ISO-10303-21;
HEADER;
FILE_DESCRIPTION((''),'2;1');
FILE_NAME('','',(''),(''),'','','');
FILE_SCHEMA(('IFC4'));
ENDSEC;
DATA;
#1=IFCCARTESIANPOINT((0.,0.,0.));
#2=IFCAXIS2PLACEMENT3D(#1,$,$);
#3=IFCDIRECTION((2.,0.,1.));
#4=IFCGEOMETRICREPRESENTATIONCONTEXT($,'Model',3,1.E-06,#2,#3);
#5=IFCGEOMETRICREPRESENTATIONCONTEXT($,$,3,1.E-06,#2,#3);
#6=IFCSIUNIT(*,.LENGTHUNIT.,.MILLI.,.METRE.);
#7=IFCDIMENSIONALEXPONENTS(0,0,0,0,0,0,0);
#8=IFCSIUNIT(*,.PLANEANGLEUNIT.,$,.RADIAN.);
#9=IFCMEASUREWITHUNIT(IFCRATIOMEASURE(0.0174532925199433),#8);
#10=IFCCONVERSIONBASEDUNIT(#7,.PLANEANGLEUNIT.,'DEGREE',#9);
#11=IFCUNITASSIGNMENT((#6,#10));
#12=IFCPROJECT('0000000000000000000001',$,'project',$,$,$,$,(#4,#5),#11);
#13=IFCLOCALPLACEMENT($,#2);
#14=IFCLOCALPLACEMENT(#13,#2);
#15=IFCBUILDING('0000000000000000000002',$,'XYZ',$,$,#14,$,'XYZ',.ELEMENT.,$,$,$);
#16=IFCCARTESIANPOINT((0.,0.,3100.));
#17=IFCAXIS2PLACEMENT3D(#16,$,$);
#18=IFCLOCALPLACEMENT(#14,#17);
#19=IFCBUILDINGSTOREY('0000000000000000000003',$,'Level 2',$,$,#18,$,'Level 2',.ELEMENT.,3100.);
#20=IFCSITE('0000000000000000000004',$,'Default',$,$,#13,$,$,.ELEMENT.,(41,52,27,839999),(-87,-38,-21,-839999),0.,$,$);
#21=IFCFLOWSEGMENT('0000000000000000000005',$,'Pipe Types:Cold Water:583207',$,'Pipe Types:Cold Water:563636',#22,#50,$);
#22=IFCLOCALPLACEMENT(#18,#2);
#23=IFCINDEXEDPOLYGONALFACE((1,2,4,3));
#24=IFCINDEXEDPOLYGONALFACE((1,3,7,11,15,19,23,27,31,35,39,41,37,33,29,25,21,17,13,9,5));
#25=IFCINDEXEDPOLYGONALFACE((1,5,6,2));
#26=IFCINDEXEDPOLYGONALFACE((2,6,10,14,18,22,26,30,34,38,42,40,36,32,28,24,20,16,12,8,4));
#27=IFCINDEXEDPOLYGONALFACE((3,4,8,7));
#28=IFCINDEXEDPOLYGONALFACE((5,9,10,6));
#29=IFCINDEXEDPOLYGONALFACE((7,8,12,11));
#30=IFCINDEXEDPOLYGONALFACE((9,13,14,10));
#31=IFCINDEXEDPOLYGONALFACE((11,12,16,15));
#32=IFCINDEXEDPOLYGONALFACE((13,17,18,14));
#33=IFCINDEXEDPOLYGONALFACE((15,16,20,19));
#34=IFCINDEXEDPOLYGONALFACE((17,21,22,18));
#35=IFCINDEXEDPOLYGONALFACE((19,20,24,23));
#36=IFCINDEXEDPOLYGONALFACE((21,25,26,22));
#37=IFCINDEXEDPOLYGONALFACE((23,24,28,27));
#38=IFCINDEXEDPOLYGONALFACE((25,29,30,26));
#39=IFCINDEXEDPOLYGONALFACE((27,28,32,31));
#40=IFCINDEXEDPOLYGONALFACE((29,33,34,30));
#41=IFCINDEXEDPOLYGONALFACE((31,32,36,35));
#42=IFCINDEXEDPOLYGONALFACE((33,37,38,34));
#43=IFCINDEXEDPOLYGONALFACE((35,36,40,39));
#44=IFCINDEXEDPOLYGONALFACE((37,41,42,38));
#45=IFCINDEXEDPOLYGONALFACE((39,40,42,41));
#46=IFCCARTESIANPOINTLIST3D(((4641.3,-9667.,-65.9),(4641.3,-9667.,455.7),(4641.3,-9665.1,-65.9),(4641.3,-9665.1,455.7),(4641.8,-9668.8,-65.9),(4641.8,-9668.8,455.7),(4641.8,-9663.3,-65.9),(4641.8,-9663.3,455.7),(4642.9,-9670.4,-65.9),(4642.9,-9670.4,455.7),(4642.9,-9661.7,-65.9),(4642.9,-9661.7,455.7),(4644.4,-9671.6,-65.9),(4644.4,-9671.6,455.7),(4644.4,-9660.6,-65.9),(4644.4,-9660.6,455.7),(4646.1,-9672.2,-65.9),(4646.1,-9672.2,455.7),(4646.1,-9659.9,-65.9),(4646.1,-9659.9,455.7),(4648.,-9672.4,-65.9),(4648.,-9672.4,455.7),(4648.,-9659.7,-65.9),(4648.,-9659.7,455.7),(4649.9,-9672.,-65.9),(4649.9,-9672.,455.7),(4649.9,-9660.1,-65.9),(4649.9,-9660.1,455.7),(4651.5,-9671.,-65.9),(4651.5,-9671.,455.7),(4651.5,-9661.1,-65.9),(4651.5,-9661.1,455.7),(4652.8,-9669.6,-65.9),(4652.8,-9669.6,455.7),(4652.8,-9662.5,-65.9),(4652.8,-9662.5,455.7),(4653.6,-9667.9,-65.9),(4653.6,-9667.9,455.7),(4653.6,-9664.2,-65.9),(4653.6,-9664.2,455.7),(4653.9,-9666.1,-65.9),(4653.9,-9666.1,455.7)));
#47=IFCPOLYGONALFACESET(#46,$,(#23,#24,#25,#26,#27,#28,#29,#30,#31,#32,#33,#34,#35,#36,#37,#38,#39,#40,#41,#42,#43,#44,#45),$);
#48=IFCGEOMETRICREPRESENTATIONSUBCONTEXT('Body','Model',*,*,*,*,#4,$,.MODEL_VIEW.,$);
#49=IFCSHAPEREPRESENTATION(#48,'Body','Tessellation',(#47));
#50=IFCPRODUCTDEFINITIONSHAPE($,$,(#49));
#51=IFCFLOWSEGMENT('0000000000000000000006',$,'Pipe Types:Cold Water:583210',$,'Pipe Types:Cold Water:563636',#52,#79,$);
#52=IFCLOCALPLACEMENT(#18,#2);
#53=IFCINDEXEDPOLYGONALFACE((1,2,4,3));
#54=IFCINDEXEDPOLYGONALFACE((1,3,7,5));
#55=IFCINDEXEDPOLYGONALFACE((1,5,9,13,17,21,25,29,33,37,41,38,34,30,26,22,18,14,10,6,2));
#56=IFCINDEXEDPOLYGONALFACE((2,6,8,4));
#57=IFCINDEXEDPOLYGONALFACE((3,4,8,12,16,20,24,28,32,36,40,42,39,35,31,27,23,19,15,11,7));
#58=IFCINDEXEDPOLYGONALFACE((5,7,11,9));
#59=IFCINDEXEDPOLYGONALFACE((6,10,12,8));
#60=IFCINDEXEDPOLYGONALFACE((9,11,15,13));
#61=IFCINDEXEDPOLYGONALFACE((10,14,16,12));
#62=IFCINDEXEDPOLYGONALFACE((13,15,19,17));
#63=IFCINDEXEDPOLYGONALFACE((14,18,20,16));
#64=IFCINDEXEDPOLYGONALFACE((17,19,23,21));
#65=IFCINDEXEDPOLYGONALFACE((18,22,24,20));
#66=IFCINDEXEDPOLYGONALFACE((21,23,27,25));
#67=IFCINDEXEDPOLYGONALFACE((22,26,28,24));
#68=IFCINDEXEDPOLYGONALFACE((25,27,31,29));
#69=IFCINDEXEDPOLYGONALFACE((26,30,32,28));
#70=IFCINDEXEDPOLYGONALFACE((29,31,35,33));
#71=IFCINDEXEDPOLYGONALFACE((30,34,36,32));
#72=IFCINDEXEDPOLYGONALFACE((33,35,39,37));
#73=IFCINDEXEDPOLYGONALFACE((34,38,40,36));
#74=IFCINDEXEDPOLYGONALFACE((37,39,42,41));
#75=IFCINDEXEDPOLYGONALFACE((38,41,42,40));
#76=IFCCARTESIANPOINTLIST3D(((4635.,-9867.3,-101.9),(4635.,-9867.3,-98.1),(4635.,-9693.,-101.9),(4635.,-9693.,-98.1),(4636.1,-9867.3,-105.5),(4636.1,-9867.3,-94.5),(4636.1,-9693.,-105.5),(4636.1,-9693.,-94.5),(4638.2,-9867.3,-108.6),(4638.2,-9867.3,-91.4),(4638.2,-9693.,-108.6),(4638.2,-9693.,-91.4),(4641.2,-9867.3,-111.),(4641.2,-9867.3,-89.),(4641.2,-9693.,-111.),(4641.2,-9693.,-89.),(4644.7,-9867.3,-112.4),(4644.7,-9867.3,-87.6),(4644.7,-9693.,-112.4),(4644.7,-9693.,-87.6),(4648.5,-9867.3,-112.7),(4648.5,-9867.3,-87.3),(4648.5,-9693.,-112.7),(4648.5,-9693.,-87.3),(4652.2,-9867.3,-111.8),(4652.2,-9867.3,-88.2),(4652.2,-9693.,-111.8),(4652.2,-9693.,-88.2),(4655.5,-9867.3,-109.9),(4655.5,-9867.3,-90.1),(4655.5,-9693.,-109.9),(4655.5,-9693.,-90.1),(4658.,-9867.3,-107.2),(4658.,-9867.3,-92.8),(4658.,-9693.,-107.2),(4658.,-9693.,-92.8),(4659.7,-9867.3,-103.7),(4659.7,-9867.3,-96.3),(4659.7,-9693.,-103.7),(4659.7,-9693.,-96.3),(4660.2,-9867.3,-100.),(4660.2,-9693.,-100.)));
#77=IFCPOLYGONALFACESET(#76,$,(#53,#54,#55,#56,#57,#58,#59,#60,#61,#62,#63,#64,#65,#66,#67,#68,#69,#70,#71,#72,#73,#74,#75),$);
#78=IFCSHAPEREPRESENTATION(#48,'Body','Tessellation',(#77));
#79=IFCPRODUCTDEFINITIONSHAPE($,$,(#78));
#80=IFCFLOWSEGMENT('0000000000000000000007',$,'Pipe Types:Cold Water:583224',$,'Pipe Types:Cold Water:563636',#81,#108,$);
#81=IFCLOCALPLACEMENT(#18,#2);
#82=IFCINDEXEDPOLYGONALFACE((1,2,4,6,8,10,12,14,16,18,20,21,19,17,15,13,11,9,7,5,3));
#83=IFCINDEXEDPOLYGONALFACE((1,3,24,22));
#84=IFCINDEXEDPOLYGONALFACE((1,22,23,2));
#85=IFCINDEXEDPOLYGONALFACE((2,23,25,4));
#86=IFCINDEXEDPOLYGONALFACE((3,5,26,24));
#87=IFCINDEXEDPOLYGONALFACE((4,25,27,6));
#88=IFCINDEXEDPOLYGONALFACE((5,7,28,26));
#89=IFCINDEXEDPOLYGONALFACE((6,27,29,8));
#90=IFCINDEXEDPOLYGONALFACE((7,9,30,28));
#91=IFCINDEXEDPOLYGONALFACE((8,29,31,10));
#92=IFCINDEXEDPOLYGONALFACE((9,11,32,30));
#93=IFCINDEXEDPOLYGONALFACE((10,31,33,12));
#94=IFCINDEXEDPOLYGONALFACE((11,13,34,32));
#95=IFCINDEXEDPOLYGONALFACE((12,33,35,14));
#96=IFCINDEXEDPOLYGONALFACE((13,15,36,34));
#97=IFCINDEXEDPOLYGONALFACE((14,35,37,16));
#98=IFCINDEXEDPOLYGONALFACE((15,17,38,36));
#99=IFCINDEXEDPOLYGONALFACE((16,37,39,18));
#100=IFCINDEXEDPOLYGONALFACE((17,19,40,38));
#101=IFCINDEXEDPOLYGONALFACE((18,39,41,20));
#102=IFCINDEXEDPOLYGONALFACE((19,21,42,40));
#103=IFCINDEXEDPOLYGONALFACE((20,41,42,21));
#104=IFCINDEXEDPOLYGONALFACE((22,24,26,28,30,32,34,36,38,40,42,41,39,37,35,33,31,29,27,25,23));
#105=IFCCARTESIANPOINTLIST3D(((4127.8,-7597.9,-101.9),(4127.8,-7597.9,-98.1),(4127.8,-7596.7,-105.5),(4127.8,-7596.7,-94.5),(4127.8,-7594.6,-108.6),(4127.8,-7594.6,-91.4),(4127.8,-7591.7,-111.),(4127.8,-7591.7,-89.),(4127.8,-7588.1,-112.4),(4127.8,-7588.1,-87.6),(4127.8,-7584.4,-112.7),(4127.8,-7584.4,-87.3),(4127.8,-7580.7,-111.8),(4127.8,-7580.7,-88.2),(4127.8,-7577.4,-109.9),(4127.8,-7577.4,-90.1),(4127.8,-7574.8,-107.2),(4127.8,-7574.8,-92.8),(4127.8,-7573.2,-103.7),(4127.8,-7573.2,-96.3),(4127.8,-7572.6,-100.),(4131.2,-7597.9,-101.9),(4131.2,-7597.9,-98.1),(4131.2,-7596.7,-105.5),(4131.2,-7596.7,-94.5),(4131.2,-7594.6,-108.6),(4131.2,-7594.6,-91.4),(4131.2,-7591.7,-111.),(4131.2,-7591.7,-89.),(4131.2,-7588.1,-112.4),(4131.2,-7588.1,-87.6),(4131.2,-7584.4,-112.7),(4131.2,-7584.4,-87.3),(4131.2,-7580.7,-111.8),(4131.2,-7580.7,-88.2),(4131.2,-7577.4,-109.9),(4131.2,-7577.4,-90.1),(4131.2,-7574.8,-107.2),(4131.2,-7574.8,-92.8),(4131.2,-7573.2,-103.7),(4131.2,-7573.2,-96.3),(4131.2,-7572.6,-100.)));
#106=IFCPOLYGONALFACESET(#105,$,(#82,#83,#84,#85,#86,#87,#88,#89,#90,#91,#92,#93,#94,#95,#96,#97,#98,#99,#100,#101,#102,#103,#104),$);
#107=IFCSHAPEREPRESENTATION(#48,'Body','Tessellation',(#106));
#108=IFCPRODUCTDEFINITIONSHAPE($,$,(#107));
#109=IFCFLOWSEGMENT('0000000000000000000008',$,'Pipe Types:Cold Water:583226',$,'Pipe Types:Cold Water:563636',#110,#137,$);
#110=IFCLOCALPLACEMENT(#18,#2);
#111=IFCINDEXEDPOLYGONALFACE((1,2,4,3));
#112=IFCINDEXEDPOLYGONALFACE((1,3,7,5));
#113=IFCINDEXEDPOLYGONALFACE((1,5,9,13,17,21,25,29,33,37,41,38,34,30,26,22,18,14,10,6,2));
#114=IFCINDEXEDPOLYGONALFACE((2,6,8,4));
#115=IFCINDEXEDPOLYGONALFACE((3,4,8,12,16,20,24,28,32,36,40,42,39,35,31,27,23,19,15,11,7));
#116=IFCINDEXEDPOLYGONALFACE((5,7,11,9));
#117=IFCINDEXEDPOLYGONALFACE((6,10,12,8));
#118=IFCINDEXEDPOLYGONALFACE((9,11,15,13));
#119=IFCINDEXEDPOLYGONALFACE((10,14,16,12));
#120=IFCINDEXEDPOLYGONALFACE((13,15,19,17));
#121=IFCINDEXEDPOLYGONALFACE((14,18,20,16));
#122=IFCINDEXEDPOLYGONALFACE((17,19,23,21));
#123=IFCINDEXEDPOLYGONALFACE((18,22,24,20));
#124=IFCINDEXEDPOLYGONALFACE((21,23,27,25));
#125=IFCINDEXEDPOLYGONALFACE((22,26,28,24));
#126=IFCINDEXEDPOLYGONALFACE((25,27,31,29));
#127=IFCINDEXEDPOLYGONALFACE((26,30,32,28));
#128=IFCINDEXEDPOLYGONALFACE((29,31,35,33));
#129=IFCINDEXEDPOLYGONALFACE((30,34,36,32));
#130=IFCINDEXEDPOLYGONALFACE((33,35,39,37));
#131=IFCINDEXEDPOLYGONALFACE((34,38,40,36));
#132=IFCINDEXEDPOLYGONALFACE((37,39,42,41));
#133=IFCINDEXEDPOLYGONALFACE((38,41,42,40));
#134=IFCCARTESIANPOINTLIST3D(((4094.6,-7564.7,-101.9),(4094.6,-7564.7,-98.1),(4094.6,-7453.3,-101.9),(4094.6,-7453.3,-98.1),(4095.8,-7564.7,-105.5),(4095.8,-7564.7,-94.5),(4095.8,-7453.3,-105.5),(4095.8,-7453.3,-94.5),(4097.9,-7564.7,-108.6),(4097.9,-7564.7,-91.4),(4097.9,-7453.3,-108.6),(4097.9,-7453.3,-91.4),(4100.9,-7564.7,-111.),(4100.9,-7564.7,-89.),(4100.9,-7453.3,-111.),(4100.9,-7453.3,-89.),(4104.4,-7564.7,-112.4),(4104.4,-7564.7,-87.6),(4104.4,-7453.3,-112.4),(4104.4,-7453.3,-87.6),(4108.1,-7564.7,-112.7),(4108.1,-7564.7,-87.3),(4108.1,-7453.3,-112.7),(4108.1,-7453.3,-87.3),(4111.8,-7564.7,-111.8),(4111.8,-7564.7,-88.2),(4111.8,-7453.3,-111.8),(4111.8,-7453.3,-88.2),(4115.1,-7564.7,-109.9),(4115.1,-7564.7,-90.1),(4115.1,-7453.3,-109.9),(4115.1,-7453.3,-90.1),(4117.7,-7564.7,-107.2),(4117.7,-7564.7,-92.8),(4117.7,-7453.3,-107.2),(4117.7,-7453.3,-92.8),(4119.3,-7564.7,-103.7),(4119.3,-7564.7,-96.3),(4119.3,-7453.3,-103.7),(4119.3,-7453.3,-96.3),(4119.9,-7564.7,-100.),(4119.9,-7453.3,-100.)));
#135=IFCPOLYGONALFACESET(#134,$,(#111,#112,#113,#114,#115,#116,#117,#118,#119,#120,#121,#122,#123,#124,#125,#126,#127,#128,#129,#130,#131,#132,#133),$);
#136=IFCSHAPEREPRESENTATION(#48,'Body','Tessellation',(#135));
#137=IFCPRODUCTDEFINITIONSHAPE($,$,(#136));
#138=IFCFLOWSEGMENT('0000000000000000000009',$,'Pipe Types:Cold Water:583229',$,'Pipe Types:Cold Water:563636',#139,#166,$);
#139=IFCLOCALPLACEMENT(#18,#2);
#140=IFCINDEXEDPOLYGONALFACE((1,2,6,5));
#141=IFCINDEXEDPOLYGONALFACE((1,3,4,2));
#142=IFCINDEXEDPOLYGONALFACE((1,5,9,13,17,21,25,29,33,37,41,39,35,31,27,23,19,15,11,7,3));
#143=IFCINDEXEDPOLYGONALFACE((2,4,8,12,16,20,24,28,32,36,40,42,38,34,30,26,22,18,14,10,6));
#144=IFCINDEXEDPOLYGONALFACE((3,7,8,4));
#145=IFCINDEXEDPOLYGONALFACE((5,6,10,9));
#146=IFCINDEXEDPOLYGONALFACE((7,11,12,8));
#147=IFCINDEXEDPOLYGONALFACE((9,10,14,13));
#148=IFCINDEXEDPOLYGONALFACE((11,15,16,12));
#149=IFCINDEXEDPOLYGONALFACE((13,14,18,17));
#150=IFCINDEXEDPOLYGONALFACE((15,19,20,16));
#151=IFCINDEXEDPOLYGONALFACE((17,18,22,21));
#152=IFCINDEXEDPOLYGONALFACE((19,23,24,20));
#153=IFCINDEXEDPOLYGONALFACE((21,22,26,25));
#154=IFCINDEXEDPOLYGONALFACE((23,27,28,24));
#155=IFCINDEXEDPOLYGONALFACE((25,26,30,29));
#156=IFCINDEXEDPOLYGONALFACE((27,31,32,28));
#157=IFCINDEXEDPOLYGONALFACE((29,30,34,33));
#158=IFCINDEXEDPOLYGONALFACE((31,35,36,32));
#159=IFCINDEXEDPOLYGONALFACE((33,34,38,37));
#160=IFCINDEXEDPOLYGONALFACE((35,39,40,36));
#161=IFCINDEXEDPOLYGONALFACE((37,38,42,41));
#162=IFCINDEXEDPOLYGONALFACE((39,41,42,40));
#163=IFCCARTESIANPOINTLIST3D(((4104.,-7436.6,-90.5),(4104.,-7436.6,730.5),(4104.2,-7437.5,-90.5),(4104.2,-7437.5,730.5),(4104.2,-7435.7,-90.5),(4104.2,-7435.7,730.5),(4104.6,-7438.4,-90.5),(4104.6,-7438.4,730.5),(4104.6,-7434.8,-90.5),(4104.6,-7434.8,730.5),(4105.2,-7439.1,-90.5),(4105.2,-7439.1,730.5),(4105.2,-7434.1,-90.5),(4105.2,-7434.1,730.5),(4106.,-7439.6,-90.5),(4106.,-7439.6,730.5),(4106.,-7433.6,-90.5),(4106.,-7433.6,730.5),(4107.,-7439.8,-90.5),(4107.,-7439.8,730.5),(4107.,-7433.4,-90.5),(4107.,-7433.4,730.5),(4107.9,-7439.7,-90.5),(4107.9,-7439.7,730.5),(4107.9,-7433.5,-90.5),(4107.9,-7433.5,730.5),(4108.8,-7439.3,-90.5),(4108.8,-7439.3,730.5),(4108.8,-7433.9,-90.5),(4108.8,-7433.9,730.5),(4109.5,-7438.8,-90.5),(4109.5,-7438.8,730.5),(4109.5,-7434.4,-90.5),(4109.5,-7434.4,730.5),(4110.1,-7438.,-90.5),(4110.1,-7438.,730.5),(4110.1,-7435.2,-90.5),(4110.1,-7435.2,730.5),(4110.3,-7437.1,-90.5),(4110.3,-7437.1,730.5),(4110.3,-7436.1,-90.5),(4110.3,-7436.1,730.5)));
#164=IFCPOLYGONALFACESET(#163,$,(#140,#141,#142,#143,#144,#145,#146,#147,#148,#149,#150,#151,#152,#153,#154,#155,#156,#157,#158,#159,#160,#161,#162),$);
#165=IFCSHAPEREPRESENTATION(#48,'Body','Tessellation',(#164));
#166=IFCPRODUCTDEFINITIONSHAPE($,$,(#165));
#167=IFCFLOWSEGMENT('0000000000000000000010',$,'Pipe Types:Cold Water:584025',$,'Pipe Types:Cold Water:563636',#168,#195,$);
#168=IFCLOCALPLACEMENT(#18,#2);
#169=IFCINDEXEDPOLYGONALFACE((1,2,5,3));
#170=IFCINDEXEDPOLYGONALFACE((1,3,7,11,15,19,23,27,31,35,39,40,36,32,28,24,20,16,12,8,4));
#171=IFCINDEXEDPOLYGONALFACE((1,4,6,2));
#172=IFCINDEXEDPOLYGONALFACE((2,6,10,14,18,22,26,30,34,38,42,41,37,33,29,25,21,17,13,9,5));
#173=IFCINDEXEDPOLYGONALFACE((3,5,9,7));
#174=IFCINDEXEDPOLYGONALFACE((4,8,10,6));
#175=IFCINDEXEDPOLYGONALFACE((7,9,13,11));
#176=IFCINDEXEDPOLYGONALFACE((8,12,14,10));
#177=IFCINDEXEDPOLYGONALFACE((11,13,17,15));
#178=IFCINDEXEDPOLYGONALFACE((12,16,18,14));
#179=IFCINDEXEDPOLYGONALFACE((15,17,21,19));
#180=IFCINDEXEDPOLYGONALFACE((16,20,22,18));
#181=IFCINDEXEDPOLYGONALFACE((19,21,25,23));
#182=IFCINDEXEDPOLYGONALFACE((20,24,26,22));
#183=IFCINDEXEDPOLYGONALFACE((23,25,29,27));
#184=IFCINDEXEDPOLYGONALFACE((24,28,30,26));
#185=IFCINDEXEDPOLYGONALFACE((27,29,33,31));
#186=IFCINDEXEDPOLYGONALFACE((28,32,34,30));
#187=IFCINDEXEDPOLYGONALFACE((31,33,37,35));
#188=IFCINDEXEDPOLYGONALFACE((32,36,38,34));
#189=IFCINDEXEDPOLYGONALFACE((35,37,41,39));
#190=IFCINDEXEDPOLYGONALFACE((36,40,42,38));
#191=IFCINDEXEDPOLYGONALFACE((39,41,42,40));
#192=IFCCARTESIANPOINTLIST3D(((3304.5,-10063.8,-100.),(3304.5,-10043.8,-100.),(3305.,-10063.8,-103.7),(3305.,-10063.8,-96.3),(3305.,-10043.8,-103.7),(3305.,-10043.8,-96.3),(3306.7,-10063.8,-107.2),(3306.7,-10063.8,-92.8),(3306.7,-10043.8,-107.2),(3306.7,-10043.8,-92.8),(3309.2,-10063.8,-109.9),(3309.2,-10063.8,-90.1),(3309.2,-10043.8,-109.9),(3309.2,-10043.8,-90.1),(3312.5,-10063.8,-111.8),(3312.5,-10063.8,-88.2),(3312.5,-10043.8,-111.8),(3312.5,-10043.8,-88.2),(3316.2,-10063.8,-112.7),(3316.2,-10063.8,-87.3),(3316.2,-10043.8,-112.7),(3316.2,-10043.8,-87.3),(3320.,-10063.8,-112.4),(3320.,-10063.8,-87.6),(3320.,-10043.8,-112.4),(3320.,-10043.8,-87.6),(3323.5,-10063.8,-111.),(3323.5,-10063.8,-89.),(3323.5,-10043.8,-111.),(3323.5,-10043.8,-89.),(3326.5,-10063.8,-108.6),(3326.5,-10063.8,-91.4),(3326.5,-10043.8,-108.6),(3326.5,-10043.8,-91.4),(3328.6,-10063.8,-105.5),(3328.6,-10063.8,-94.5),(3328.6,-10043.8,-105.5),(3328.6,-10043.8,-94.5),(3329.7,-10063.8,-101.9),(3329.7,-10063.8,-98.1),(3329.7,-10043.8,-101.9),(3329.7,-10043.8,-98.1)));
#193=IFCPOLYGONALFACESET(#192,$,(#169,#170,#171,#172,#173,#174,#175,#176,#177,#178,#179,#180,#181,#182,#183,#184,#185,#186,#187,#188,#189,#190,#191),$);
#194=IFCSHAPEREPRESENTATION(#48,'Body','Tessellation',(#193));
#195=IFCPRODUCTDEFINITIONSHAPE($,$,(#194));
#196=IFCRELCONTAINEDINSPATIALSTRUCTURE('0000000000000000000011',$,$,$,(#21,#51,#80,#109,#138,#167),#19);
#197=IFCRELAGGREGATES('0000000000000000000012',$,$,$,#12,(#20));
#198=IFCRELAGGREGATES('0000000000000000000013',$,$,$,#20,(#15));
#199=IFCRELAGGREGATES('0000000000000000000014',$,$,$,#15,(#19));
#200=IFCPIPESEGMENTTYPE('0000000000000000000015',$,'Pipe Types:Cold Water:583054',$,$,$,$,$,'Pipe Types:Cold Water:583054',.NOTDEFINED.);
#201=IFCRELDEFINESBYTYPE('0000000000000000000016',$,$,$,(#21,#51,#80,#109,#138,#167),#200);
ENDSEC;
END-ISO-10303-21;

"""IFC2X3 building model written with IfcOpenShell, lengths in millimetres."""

from ifc_helpers import new_model, entity, si_unit, converted_unit, direction, frame, frame_2d, origin, origin_2d_with_axis, place, context, subcontext, project, spatial, circle, extrude, type_object, element, save


model = new_model("IFC2X3")

# Units and contexts
model_context = context("Model", 3, precision=1e-06, world=origin(), true_north=direction((2.0, 0.0, 1.0)))
context_of_model = context(None, 3, precision=1e-06, world=origin(), true_north=direction((2.0, 0.0, 1.0)))
body_context = subcontext(model_context, "Body", "Model", "MODEL_VIEW")
ifc_project = project(units=[si_unit("LENGTHUNIT", "METRE", prefix="MILLI"), converted_unit("PLANEANGLEUNIT", "DEGREE", entity("IfcRatioMeasure", 0.0174532925199433), si_unit("PLANEANGLEUNIT", "RADIAN"), dimensions=[0, 0, 0, 0, 0, 0, 0])], contexts=[model_context, context_of_model])

# Site, building, storey
site_placement = place(None, origin())
site = spatial("IfcSite", under=ifc_project, at=site_placement, Name="Default", CompositionType="ELEMENT", RefLatitude=(41, 52, 27, 839999), RefLongitude=(-87, -38, -21, -839999), RefElevation=0.0)
building_placement = place(site_placement, origin())
building = spatial("IfcBuilding", under=site, at=building_placement, Name="XYZ", LongName="XYZ", CompositionType="ELEMENT")
storey_placement = place(building_placement, frame((0.0, 0.0, 3100.0)))
storey = spatial("IfcBuildingStorey", under=building, at=storey_placement, Name="Level 2", LongName="Level 2", CompositionType="ELEMENT", Elevation=3100.0)

# Flow segments
pipe_segment_type_1 = type_object("IfcPipeSegmentType", Name="Pipe Types:Cold Water:583054", ElementType="Pipe Types:Cold Water:583054", PredefinedType="NOTDEFINED")
flow_segment_1_placement = place(storey_placement, origin())
element("IfcFlowSegment", 1, at=flow_segment_1_placement, inside=storey, type_object=pipe_segment_type_1, Name="Pipe Types:Cold Water:583207", ObjectType="Pipe Types:Cold Water:563636", context=body_context, shape_type="SweptSolid", body=[
    extrude(circle(Radius=6.3, at=origin_2d_with_axis()), frame((4647.5, -9666.1, -65.9)), (0.0, 0.0, 1.0), 521.5),
])
flow_segment_2_placement = place(storey_placement, origin())
element("IfcFlowSegment", 2, at=flow_segment_2_placement, inside=storey, type_object=pipe_segment_type_1, Name="Pipe Types:Cold Water:583210", ObjectType="Pipe Types:Cold Water:563636", context=body_context, shape_type="SweptSolid", body=[
    extrude(circle(Radius=12.7, at=origin_2d_with_axis()), frame((4647.5, -9867.3, -100.0), z_axis=(0.0, 1.0, 0.0), x_axis=(1.0, 0.0, 0.0)), (0.0, 0.0, 1.0), 174.2),
])
flow_segment_3_placement = place(storey_placement, origin())
element("IfcFlowSegment", 3, at=flow_segment_3_placement, inside=storey, type_object=pipe_segment_type_1, Name="Pipe Types:Cold Water:583224", ObjectType="Pipe Types:Cold Water:563636", context=body_context, shape_type="SweptSolid", body=[
    extrude(circle(Radius=12.7, at=frame_2d((0.0, 0.0), x_axis=(1.0, 0.0))), frame((4127.8, -7585.3, -100.0), z_axis=(1.0, 0.0, 0.0), x_axis=(0.0, 1.0, 0.0)), (0.0, 0.0, 1.0), 3.4),
])
flow_segment_4_placement = place(storey_placement, origin())
element("IfcFlowSegment", 4, at=flow_segment_4_placement, inside=storey, type_object=pipe_segment_type_1, Name="Pipe Types:Cold Water:583226", ObjectType="Pipe Types:Cold Water:563636", context=body_context, shape_type="SweptSolid", body=[
    extrude(circle(Radius=12.7, at=origin_2d_with_axis()), frame((4107.2, -7564.7, -100.0), z_axis=(0.0, 1.0, 0.0), x_axis=(1.0, 0.0, 0.0)), (0.0, 0.0, 1.0), 111.4),
])
flow_segment_5_placement = place(storey_placement, origin())
element("IfcFlowSegment", 5, at=flow_segment_5_placement, inside=storey, type_object=pipe_segment_type_1, Name="Pipe Types:Cold Water:583229", ObjectType="Pipe Types:Cold Water:563636", context=body_context, shape_type="SweptSolid", body=[
    extrude(circle(Radius=3.2, at=origin_2d_with_axis()), frame((4107.2, -7436.6, -90.5), z_axis=(0.0, 0.0, 1.0), x_axis=(-1.0, 0.0, 0.0)), (0.0, 0.0, 1.0), 821.0),
])
flow_segment_6_placement = place(storey_placement, origin())
element("IfcFlowSegment", 6, at=flow_segment_6_placement, inside=storey, type_object=pipe_segment_type_1, Name="Pipe Types:Cold Water:584025", ObjectType="Pipe Types:Cold Water:563636", context=body_context, shape_type="SweptSolid", body=[
    extrude(circle(Radius=12.7, at=origin_2d_with_axis()), frame((3317.2, -10063.8, -100.0), z_axis=(0.0, 1.0, 0.0), x_axis=(-1.0, 0.0, 0.0)), (0.0, 0.0, 1.0), 19.9),
])

save(model, "model.ifc")
